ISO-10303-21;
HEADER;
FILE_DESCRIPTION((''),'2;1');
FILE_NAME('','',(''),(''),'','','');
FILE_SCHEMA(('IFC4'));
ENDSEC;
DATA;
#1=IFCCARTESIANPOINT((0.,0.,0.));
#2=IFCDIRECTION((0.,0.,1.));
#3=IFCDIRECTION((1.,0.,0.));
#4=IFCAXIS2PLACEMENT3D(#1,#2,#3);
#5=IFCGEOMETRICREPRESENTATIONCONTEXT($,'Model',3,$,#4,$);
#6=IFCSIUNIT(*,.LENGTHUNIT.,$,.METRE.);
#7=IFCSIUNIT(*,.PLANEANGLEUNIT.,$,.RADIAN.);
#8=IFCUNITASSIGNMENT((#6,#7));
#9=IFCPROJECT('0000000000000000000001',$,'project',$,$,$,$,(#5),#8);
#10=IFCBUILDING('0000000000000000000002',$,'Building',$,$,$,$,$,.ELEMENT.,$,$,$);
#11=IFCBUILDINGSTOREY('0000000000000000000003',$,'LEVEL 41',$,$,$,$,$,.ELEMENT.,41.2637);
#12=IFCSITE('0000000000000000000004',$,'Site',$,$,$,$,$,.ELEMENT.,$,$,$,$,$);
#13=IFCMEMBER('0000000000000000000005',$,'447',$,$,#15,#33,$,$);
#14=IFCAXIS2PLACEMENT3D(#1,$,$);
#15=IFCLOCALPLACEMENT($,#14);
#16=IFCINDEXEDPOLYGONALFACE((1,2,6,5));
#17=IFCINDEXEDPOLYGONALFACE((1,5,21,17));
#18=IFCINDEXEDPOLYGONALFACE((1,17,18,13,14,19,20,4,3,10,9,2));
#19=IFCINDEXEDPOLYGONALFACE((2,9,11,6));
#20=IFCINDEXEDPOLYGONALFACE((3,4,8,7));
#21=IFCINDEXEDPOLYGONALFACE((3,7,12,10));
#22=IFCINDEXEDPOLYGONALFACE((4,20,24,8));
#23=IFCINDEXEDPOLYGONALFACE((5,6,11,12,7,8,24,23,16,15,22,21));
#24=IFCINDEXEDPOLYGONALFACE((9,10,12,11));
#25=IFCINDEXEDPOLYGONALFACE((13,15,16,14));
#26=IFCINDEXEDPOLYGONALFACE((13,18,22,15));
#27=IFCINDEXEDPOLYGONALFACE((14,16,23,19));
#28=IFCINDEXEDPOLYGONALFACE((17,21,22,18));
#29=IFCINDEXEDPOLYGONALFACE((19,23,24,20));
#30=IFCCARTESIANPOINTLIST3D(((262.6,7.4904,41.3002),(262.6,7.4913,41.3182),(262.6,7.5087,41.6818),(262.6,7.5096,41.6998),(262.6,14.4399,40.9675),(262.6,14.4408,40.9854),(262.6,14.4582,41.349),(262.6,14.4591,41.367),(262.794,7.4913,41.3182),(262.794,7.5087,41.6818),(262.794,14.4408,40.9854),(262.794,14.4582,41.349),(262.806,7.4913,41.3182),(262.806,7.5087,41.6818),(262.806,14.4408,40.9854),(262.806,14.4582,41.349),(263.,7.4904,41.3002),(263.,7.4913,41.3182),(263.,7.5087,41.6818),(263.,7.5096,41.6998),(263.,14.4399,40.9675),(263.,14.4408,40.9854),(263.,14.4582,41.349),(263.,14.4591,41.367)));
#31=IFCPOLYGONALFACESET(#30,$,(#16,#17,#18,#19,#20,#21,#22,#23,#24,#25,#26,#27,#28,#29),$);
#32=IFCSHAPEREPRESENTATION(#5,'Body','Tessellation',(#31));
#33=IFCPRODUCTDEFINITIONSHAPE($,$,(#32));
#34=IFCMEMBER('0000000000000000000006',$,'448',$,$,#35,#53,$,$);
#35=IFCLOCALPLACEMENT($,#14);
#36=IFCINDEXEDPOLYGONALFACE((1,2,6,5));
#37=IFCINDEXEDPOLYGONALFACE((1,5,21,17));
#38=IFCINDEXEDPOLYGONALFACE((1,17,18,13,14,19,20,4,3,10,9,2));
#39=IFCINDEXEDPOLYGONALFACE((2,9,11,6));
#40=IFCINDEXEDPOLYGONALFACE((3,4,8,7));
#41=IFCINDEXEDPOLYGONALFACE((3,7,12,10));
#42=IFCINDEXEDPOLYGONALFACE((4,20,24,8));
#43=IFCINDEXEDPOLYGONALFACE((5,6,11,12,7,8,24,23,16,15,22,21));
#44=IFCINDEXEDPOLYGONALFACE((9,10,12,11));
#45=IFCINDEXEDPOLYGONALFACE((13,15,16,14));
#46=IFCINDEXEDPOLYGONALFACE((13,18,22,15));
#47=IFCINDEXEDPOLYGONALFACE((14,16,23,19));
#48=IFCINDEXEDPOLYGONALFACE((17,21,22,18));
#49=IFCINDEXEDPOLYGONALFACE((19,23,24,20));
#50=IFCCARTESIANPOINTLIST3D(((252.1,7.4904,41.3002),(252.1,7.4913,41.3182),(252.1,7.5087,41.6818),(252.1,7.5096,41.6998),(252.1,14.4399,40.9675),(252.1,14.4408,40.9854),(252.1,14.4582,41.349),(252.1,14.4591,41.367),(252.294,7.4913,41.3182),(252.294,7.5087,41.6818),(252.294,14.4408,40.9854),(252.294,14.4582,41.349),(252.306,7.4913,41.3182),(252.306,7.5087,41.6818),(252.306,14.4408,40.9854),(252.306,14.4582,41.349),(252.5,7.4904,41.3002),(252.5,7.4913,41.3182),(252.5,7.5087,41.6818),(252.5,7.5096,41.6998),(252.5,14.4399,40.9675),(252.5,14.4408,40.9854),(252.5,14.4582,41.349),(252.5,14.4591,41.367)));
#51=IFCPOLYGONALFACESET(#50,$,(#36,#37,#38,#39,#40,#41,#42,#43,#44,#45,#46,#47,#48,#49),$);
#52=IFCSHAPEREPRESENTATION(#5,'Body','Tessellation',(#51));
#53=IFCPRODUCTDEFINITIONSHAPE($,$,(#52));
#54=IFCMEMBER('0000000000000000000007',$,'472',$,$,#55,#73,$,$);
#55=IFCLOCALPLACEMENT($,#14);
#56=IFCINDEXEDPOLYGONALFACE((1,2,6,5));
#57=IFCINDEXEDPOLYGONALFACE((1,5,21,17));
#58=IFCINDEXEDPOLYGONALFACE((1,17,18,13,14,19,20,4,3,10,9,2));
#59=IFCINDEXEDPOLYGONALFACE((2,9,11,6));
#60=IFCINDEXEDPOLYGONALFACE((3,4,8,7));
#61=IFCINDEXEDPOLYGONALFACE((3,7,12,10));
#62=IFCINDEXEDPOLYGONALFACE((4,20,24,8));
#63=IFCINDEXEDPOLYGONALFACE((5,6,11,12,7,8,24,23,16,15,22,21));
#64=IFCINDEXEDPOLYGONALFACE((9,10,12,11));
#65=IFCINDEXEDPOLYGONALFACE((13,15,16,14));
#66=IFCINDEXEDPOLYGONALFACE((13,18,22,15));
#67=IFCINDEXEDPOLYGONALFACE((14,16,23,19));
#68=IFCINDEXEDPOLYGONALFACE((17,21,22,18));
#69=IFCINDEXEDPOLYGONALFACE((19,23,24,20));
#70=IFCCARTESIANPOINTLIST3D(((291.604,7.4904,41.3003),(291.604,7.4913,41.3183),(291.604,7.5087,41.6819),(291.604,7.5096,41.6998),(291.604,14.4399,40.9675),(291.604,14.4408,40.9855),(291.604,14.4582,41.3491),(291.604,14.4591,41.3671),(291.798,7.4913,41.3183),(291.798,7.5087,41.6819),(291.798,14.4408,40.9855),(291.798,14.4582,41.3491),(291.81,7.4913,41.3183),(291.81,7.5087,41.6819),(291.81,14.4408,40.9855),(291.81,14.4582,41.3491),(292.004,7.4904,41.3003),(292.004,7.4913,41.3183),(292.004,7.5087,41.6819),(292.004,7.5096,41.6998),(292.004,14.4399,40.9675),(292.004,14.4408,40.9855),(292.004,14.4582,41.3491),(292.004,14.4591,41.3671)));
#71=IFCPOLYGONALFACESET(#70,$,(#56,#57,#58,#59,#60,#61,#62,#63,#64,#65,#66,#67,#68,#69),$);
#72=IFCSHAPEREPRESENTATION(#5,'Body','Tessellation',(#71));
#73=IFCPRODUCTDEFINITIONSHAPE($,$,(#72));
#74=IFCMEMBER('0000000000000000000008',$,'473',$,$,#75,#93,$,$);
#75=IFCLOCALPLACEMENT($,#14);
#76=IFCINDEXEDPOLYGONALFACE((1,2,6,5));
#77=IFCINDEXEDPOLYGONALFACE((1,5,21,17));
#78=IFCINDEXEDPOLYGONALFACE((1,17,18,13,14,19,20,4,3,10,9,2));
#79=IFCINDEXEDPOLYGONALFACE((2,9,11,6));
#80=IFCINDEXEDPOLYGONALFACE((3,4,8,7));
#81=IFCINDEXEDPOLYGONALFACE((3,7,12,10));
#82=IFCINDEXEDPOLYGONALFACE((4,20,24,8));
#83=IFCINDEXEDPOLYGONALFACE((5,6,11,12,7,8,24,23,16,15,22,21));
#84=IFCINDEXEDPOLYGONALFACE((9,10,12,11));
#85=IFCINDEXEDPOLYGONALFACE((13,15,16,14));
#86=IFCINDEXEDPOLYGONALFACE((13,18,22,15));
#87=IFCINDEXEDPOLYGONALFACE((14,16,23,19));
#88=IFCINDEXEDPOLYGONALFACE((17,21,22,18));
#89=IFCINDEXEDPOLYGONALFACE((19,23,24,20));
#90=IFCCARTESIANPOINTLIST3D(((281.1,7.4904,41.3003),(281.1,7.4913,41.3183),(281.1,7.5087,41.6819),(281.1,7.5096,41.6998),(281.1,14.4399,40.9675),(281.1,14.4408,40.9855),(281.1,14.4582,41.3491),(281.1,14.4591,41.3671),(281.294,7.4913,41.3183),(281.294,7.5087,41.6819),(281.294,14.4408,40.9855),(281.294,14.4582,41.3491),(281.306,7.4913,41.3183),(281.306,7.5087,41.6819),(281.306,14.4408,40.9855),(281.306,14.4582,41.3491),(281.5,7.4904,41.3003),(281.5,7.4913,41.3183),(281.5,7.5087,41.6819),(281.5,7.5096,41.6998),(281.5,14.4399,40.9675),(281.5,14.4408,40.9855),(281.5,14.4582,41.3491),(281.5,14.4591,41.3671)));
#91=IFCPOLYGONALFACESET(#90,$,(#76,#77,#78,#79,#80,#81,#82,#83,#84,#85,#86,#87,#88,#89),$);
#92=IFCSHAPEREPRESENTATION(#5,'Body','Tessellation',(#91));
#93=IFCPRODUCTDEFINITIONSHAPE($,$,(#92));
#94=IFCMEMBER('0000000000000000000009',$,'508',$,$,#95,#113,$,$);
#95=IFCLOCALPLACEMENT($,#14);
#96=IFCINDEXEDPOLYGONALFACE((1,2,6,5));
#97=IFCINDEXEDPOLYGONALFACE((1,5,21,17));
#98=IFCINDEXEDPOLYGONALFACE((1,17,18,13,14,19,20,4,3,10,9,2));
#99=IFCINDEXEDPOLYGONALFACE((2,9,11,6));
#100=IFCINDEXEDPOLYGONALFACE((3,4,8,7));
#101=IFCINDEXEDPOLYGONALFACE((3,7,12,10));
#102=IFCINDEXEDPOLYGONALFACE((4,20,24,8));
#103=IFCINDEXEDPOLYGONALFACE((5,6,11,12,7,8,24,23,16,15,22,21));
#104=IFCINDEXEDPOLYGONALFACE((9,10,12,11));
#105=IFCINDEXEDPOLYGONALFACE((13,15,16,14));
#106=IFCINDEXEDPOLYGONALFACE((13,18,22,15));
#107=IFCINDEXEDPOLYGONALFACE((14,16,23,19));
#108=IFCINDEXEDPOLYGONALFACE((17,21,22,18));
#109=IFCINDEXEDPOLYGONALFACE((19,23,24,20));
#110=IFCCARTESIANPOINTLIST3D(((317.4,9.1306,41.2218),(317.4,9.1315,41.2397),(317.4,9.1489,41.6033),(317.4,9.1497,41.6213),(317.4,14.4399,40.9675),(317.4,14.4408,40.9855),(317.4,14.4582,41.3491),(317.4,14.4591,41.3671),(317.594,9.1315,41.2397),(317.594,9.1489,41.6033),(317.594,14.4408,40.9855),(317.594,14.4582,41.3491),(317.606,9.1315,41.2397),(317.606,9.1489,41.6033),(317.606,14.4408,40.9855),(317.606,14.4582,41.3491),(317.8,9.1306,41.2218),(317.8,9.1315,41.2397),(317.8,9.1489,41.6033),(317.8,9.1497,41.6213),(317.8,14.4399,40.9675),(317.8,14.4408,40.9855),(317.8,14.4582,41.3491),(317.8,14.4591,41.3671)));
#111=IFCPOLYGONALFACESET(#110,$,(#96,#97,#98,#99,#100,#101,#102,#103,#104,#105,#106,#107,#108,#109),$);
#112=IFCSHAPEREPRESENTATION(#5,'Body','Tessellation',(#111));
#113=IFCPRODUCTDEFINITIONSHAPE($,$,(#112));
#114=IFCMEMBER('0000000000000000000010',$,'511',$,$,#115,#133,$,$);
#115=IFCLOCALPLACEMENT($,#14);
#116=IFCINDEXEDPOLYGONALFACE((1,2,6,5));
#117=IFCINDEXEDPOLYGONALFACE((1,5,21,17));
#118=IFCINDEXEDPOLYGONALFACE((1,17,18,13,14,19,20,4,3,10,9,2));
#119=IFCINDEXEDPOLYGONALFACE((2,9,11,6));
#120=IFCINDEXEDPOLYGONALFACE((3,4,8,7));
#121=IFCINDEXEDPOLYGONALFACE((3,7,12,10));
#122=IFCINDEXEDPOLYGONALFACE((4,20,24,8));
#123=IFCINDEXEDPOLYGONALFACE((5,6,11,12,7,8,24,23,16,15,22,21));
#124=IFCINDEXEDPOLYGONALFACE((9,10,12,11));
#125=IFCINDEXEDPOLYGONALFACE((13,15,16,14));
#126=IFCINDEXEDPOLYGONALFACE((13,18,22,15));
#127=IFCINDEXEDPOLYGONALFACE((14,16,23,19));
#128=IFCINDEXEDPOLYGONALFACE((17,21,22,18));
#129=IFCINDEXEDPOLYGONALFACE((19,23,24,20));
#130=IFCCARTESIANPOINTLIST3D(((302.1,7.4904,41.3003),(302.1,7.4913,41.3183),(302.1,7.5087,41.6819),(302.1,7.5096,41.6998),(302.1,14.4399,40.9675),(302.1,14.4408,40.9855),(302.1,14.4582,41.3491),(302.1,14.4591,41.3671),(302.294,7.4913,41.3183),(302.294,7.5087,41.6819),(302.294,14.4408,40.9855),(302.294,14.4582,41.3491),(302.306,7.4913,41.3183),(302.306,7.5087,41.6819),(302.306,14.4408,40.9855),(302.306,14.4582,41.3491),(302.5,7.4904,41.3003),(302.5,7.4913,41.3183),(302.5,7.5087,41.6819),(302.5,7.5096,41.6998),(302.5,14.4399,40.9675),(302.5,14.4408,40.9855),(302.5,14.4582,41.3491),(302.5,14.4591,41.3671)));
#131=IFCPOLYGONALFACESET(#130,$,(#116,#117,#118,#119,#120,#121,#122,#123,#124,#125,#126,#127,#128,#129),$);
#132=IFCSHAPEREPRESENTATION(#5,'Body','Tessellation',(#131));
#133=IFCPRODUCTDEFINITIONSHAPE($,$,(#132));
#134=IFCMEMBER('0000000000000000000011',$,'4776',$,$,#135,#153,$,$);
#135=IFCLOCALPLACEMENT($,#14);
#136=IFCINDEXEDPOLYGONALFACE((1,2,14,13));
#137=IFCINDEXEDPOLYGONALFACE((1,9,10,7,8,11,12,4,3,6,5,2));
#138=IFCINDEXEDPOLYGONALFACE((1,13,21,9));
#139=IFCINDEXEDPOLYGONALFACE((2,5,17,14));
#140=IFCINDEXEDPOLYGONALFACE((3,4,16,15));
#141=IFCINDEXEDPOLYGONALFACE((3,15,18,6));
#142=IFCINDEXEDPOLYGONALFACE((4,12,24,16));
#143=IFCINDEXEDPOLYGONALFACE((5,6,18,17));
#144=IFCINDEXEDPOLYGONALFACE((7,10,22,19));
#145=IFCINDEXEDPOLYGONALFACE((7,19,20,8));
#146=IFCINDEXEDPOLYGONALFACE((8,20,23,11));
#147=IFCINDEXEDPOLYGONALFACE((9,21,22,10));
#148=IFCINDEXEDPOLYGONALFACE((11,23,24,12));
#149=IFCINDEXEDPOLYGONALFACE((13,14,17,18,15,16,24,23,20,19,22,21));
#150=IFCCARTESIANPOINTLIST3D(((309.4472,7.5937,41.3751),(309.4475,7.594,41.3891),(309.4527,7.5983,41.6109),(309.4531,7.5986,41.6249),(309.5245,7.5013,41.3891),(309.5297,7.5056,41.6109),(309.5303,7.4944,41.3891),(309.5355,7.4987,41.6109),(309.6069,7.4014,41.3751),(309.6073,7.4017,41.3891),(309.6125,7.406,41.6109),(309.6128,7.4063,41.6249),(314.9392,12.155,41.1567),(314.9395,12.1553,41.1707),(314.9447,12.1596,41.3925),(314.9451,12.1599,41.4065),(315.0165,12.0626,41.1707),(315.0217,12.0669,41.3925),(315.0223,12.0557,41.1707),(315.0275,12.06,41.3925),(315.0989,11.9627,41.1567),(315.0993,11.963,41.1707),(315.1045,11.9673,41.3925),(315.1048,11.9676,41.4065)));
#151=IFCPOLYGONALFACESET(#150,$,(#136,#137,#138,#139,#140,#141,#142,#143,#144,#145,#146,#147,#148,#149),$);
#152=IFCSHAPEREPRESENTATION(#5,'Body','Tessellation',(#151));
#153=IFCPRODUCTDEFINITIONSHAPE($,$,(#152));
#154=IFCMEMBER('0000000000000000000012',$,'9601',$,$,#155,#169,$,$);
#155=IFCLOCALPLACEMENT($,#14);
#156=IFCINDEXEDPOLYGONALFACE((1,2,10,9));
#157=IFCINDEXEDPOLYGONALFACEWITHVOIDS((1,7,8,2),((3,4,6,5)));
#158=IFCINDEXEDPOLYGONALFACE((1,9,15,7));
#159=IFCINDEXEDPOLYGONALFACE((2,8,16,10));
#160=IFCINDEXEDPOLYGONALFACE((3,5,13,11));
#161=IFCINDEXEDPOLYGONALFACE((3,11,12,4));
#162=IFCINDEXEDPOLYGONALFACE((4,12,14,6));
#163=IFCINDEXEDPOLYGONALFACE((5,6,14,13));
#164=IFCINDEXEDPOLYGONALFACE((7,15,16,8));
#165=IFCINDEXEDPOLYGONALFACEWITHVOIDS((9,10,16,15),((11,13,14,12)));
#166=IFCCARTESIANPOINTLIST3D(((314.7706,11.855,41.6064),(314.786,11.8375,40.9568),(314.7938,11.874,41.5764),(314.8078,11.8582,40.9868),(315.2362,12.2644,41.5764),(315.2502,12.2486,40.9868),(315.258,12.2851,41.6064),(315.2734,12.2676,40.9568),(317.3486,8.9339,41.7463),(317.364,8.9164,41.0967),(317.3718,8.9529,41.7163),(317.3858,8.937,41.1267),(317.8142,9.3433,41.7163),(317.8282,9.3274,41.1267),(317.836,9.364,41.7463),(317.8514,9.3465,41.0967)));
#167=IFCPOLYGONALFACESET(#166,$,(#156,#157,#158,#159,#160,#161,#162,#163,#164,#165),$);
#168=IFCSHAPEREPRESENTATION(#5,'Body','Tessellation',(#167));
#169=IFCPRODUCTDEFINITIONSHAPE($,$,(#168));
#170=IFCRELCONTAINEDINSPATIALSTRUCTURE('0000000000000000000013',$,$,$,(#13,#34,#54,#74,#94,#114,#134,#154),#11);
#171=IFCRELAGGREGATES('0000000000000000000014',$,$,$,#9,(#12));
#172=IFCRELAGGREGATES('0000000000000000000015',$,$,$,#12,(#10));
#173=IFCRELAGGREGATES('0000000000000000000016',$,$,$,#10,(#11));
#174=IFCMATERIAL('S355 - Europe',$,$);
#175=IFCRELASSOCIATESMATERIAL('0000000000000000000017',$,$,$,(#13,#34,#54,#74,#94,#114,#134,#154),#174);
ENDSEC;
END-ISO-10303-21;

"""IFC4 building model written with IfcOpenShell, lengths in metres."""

from ifc_helpers import new_model, si_unit, frame, origin_with_axes, origin_2d_with_axis, place, context, project, spatial, hollow_rectangle, i_section, extrude, material, material_profile, profile_set, profile_usage, element, save


model = new_model("IFC4")

# Units and contexts
model_context = context("Model", 3, world=origin_with_axes())
ifc_project = project(units=[si_unit("LENGTHUNIT", "METRE"), si_unit("PLANEANGLEUNIT", "RADIAN")], contexts=[model_context])

# Site, building, storey
site = spatial("IfcSite", under=ifc_project, Name="Site", CompositionType="ELEMENT")
building = spatial("IfcBuilding", under=site, Name="Building", CompositionType="ELEMENT")
storey = spatial("IfcBuildingStorey", under=building, Name="LEVEL 41", CompositionType="ELEMENT", Elevation=41.2637)

# Shared definitions
ifc_material = material(Name="S355 - Europe")

# Members
ifc_material_profile_1 = material_profile(ifc_material, i_section(OverallWidth=0.4, OverallDepth=0.4, WebThickness=0.012, FlangeThickness=0.018, at=origin_2d_with_axis()))
ifc_profile_set_1 = profile_set([ifc_material_profile_1])
ifc_profile_usage_1 = profile_usage(ifc_profile_set_1, cardinal=10)
member_1_placement = place(None, frame((262.8, 7.5, 41.5), z_axis=(0.0, 0.998856, -0.047828), x_axis=(-1.0, 0.0, 0.0)))
element("IfcMember", 1, at=member_1_placement, inside=storey, material=ifc_profile_usage_1, Name="447", context=model_context, shape_type="SweptSolid", body=[
    extrude(i_section(OverallWidth=0.4, OverallDepth=0.4, WebThickness=0.012, FlangeThickness=0.018, at=origin_2d_with_axis()), origin_with_axes(), (0.0, 0.0, 1.0), 6.9575),
])
ifc_material_profile_2 = material_profile(ifc_material, i_section(OverallWidth=0.4, OverallDepth=0.4, WebThickness=0.012, FlangeThickness=0.018, at=origin_2d_with_axis()))
ifc_profile_set_2 = profile_set([ifc_material_profile_2])
ifc_profile_usage_2 = profile_usage(ifc_profile_set_2, cardinal=10)
member_2_placement = place(None, frame((252.3, 7.5, 41.5), z_axis=(0.0, 0.998856, -0.047828), x_axis=(-1.0, 0.0, 0.0)))
element("IfcMember", 2, at=member_2_placement, inside=storey, material=ifc_profile_usage_2, Name="448", context=model_context, shape_type="SweptSolid", body=[
    extrude(i_section(OverallWidth=0.4, OverallDepth=0.4, WebThickness=0.012, FlangeThickness=0.018, at=origin_2d_with_axis()), origin_with_axes(), (0.0, 0.0, 1.0), 6.9575),
])
ifc_material_profile_3 = material_profile(ifc_material, i_section(OverallWidth=0.4, OverallDepth=0.4, WebThickness=0.012, FlangeThickness=0.018, at=origin_2d_with_axis()))
ifc_profile_set_3 = profile_set([ifc_material_profile_3])
ifc_profile_usage_3 = profile_usage(ifc_profile_set_3, cardinal=10)
member_3_placement = place(None, frame((291.804, 14.4495, 41.1673), z_axis=(0.0, -0.998856, 0.047828), x_axis=(1.0, 0.0, 0.0)))
element("IfcMember", 3, at=member_3_placement, inside=storey, material=ifc_profile_usage_3, Name="472", context=model_context, shape_type="SweptSolid", body=[
    extrude(i_section(OverallWidth=0.4, OverallDepth=0.4, WebThickness=0.012, FlangeThickness=0.018, at=origin_2d_with_axis()), origin_with_axes(), (0.0, 0.0, 1.0), 6.9575),
])
ifc_material_profile_4 = material_profile(ifc_material, i_section(OverallWidth=0.4, OverallDepth=0.4, WebThickness=0.012, FlangeThickness=0.018, at=origin_2d_with_axis()))
ifc_profile_set_4 = profile_set([ifc_material_profile_4])
ifc_profile_usage_4 = profile_usage(ifc_profile_set_4, cardinal=10)
member_4_placement = place(None, frame((281.3, 14.4495, 41.1673), z_axis=(0.0, -0.998856, 0.047828), x_axis=(1.0, 0.0, 0.0)))
element("IfcMember", 4, at=member_4_placement, inside=storey, material=ifc_profile_usage_4, Name="473", context=model_context, shape_type="SweptSolid", body=[
    extrude(i_section(OverallWidth=0.4, OverallDepth=0.4, WebThickness=0.012, FlangeThickness=0.018, at=origin_2d_with_axis()), origin_with_axes(), (0.0, 0.0, 1.0), 6.9575),
])
ifc_material_profile_5 = material_profile(ifc_material, i_section(OverallWidth=0.4, OverallDepth=0.4, WebThickness=0.012, FlangeThickness=0.018, at=origin_2d_with_axis()))
ifc_profile_set_5 = profile_set([ifc_material_profile_5])
ifc_profile_usage_5 = profile_usage(ifc_profile_set_5, cardinal=10)
member_5_placement = place(None, frame((317.6, 14.4495, 41.1673), z_axis=(0.0, -0.998856, 0.047828), x_axis=(1.0, 0.0, 0.0)))
element("IfcMember", 5, at=member_5_placement, inside=storey, material=ifc_profile_usage_5, Name="508", context=model_context, shape_type="SweptSolid", body=[
    extrude(i_section(OverallWidth=0.4, OverallDepth=0.4, WebThickness=0.012, FlangeThickness=0.018, at=origin_2d_with_axis()), origin_with_axes(), (0.0, 0.0, 1.0), 5.3154),
])
ifc_material_profile_6 = material_profile(ifc_material, i_section(OverallWidth=0.4, OverallDepth=0.4, WebThickness=0.012, FlangeThickness=0.018, at=origin_2d_with_axis()))
ifc_profile_set_6 = profile_set([ifc_material_profile_6])
ifc_profile_usage_6 = profile_usage(ifc_profile_set_6, cardinal=10)
member_6_placement = place(None, frame((302.3, 14.4495, 41.1673), z_axis=(0.0, -0.998856, 0.047828), x_axis=(1.0, 0.0, 0.0)))
element("IfcMember", 6, at=member_6_placement, inside=storey, material=ifc_profile_usage_6, Name="511", context=model_context, shape_type="SweptSolid", body=[
    extrude(i_section(OverallWidth=0.4, OverallDepth=0.4, WebThickness=0.012, FlangeThickness=0.018, at=origin_2d_with_axis()), origin_with_axes(), (0.0, 0.0, 1.0), 6.9575),
])
ifc_material_profile_7 = material_profile(ifc_material, i_section(OverallWidth=0.25, OverallDepth=0.25, WebThickness=0.009, FlangeThickness=0.014, at=origin_2d_with_axis()))
ifc_profile_set_7 = profile_set([ifc_material_profile_7])
ifc_profile_usage_7 = profile_usage(ifc_profile_set_7, cardinal=10)
member_7_placement = place(None, frame((309.53, 7.5, 41.5), z_axis=(0.768919, 0.638614, -0.030578), x_axis=(-0.638913, 0.769279, 0.0)))
element("IfcMember", 7, at=member_7_placement, inside=storey, material=ifc_profile_usage_7, Name="4776", context=model_context, shape_type="SweptSolid", body=[
    extrude(i_section(OverallWidth=0.25, OverallDepth=0.25, WebThickness=0.009, FlangeThickness=0.014, at=origin_2d_with_axis()), origin_with_axes(), (0.0, 0.0, 1.0), 7.1425),
])
ifc_material_profile_8 = material_profile(ifc_material, hollow_rectangle(XDim=0.65, YDim=0.65, WallThickness=0.03, at=origin_2d_with_axis()))
ifc_profile_set_8 = profile_set([ifc_material_profile_8])
ifc_profile_usage_8 = profile_usage(ifc_profile_set_8, cardinal=10)
member_8_placement = place(None, frame((315.022, 12.0613, 41.2816), z_axis=(0.661272, -0.749287, 0.035885), x_axis=(0.74977, 0.661698, 0.0)))
element("IfcMember", 8, at=member_8_placement, inside=storey, material=ifc_profile_usage_8, Name="9601", context=model_context, shape_type="SweptSolid", body=[
    extrude(hollow_rectangle(XDim=0.65, YDim=0.65, WallThickness=0.03, at=origin_2d_with_axis()), origin_with_axes(), (0.0, 0.0, 1.0), 3.8985),
])

save(model, "model.ifc")
